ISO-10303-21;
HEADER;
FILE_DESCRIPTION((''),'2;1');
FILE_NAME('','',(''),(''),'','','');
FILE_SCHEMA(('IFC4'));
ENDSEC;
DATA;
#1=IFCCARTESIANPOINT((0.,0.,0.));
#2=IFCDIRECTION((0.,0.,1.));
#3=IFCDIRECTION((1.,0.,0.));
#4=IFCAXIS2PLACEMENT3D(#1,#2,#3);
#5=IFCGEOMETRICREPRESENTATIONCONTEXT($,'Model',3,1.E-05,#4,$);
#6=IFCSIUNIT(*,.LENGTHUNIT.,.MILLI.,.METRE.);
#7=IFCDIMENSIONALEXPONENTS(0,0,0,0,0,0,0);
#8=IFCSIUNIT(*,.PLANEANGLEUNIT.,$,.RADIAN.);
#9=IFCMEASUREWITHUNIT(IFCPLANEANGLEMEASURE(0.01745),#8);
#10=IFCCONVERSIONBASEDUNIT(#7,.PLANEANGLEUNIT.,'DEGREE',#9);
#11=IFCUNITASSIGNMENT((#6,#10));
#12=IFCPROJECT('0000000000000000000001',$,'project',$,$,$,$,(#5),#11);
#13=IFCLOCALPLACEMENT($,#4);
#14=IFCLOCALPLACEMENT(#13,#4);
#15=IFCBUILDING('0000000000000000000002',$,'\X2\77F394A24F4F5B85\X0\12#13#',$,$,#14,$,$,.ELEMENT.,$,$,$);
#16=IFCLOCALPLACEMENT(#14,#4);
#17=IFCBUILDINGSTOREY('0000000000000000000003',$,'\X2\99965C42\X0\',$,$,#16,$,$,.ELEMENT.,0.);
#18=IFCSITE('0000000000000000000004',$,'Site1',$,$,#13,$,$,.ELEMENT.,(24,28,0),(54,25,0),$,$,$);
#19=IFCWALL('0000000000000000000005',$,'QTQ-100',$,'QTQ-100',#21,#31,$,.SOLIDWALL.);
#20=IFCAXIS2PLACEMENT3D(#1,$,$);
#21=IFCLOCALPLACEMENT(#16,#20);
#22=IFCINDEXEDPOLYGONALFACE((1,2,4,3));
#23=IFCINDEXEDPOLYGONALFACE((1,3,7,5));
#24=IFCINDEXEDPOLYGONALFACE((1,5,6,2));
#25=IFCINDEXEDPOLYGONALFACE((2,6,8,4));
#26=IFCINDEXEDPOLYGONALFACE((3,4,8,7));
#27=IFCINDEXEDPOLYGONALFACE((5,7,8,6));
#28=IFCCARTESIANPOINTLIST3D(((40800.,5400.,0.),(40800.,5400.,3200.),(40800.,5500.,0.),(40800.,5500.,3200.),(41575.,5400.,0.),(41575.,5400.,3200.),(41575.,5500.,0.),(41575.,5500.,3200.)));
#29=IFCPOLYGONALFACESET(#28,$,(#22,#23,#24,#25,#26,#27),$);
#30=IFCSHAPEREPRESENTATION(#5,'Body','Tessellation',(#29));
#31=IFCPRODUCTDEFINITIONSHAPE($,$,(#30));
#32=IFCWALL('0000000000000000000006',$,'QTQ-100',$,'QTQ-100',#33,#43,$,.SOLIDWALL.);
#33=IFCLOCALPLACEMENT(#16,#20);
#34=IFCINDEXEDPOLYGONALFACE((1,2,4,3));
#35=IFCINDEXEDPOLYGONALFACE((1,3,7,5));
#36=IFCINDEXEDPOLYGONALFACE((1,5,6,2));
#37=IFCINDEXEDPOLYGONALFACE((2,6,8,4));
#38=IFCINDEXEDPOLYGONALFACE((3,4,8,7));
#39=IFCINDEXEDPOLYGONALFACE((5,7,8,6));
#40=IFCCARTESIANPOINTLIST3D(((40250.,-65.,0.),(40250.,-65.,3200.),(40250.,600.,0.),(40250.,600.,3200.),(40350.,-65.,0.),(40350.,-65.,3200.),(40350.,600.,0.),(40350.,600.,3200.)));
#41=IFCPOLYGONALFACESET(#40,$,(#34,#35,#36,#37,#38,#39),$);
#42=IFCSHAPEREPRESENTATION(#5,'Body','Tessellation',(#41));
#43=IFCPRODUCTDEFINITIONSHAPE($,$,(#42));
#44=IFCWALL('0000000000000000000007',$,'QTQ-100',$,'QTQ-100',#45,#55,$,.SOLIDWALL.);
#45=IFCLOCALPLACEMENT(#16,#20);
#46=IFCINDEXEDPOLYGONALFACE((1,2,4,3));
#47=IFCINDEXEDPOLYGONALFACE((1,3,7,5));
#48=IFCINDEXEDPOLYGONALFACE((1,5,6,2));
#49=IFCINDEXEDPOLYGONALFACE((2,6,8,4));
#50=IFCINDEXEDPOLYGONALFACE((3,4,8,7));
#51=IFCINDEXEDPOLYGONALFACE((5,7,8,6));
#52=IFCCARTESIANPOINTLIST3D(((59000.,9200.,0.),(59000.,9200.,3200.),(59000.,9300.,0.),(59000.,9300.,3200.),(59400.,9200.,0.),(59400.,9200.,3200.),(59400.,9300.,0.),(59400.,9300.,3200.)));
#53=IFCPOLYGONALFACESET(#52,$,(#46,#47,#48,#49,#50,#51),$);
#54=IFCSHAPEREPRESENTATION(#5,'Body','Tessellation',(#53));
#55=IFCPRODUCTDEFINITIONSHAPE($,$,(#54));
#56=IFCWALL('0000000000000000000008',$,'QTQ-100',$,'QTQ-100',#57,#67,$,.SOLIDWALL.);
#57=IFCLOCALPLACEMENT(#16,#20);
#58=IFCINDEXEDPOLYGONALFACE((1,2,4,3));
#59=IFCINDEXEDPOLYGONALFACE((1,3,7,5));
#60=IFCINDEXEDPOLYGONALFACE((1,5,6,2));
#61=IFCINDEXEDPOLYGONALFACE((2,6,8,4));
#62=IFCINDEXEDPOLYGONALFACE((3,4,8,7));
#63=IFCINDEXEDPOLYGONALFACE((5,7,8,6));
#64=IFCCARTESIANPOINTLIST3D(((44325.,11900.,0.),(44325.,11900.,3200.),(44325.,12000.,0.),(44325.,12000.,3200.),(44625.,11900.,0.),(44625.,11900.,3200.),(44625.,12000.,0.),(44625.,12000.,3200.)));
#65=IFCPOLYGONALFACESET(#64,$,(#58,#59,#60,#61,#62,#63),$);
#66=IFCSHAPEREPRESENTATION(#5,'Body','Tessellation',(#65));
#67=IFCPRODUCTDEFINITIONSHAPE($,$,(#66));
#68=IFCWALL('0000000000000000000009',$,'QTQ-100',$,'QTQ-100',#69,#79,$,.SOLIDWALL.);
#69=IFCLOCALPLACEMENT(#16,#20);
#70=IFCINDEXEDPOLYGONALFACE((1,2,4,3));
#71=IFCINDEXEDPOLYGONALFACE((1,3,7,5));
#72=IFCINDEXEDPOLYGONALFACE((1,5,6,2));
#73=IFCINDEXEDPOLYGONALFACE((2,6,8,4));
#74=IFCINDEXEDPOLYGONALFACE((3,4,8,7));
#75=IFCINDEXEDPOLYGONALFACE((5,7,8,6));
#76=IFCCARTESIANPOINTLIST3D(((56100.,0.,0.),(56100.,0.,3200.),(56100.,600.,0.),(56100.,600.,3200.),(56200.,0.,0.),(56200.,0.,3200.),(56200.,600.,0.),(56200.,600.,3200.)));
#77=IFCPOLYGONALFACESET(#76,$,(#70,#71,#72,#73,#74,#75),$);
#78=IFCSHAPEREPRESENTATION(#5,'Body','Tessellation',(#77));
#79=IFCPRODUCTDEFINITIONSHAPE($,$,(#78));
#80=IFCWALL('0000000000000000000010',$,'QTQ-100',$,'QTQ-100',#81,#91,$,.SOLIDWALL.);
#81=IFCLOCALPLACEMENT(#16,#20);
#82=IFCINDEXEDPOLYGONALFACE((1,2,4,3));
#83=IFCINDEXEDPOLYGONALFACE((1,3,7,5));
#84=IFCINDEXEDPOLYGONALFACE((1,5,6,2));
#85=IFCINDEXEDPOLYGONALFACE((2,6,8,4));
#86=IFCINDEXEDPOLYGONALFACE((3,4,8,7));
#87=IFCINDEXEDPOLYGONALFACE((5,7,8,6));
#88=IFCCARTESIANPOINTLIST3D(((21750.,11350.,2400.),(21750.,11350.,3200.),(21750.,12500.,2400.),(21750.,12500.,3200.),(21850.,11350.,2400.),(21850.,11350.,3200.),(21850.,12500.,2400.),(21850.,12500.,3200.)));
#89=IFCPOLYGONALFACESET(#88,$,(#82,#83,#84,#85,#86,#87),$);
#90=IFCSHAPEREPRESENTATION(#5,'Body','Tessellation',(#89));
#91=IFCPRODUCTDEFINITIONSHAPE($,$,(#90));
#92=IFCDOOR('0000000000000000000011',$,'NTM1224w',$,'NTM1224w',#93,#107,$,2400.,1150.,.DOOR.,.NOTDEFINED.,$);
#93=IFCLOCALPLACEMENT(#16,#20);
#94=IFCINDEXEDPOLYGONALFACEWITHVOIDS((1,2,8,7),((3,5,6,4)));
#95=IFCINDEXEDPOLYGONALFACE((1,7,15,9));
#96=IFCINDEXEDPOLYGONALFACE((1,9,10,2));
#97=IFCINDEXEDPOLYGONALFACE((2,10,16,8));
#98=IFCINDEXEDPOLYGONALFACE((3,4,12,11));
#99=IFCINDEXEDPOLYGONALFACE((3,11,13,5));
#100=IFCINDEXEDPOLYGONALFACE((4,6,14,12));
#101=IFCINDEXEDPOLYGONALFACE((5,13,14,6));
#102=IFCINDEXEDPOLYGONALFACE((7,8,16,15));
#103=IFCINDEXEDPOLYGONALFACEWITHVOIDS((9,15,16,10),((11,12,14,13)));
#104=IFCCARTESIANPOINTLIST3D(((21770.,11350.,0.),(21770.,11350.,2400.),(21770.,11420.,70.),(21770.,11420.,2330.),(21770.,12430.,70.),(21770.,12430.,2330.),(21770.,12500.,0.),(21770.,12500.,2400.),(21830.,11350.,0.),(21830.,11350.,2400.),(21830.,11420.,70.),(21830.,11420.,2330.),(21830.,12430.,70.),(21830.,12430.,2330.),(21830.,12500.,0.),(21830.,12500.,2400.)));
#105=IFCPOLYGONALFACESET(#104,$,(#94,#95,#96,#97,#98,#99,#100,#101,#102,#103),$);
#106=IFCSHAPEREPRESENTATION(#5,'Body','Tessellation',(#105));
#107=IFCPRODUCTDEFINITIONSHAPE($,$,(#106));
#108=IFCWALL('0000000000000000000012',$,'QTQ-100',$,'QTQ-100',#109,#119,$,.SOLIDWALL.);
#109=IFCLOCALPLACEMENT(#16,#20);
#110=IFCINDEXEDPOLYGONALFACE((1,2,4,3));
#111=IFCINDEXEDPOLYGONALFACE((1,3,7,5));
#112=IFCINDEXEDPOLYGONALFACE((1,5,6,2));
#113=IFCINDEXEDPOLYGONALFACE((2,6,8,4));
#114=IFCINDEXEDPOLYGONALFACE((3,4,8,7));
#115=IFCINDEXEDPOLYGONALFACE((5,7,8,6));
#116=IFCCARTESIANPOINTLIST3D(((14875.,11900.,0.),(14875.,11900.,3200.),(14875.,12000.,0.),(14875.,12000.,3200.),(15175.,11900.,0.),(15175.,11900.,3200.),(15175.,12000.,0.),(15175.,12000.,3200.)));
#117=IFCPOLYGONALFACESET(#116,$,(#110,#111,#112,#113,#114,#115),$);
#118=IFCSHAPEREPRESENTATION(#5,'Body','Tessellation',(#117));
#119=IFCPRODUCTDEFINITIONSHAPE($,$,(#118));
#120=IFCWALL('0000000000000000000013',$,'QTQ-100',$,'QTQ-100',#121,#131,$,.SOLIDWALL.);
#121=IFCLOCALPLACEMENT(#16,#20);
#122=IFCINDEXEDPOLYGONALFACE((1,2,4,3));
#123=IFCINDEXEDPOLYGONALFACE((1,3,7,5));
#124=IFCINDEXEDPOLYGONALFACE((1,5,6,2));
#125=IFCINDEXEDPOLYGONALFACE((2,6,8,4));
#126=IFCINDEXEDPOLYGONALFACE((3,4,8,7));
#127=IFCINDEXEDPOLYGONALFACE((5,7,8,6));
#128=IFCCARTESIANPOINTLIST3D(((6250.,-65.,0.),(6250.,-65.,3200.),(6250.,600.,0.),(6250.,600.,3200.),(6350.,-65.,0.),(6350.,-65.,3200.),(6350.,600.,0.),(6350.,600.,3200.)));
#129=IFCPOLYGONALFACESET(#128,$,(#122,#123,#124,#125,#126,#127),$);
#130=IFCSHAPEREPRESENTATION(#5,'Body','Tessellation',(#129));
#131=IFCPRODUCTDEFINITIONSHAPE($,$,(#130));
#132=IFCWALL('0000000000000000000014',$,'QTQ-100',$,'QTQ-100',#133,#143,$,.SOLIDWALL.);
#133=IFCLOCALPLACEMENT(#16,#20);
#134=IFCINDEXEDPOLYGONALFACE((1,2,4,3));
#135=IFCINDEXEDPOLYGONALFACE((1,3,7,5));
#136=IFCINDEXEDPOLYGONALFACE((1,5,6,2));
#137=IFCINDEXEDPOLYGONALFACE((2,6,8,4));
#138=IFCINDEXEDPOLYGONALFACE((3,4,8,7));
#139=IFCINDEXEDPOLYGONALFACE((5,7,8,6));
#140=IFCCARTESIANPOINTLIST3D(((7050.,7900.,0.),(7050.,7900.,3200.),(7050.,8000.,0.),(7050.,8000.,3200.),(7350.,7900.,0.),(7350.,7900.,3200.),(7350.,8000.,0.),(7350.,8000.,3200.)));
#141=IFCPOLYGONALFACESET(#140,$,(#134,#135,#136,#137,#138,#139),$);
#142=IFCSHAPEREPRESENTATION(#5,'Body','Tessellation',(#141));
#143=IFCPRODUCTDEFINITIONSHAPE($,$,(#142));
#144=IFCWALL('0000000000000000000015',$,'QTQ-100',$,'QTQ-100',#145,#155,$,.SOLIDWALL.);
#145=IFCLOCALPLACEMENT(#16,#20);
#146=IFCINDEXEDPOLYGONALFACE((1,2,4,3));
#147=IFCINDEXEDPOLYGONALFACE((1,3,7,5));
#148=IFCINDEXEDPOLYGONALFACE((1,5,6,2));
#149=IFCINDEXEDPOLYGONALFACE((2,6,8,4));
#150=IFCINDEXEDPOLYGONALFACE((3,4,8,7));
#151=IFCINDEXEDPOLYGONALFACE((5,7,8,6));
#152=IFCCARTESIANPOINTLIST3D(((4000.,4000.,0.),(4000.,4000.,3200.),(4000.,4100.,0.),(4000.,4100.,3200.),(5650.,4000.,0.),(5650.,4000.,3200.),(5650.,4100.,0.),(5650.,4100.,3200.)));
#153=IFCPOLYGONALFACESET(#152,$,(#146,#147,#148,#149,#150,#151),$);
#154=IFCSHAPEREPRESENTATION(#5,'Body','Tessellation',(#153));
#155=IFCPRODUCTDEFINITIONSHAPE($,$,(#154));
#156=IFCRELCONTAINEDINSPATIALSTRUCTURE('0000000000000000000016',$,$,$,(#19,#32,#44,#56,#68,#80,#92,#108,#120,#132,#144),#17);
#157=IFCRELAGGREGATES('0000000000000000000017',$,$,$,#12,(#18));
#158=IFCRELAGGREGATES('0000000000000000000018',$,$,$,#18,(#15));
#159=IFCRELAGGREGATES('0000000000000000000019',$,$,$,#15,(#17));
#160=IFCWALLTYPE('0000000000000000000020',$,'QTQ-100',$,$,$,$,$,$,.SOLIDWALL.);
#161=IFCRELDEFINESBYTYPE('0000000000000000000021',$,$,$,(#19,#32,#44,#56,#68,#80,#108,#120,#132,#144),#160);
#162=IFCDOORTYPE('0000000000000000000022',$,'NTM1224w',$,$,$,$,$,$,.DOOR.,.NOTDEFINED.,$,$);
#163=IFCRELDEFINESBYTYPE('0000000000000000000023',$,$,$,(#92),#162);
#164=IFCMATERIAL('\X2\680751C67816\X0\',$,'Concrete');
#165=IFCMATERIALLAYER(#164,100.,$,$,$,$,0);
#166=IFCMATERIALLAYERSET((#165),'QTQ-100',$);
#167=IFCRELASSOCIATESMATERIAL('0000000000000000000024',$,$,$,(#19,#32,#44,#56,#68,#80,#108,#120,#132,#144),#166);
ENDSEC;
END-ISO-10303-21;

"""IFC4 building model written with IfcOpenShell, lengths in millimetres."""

from ifc_helpers import new_model, entity, si_unit, converted_unit, frame, origin_with_axes, place, context, project, spatial, polyline, outline, extrude, material, layer, layer_set, type_object, element, fill, save


model = new_model("IFC4")

# Units and contexts
model_context = context("Model", 3, precision=1e-05, world=origin_with_axes())
ifc_project = project(units=[si_unit("LENGTHUNIT", "METRE", prefix="MILLI"), converted_unit("PLANEANGLEUNIT", "DEGREE", entity("IfcPlaneAngleMeasure", 0.01745), si_unit("PLANEANGLEUNIT", "RADIAN"), dimensions=[0, 0, 0, 0, 0, 0, 0])], contexts=[model_context])

# Site, building, storey
site_placement = place(None, origin_with_axes())
site = spatial("IfcSite", under=ifc_project, at=site_placement, Name="Site1", CompositionType="ELEMENT", RefLatitude=(24, 28, 0), RefLongitude=(54, 25, 0))
building_placement = place(site_placement, origin_with_axes())
building = spatial("IfcBuilding", under=site, at=building_placement, Name="石钢住宅12#13#", CompositionType="ELEMENT")
storey_placement = place(building_placement, origin_with_axes())
storey = spatial("IfcBuildingStorey", under=building, at=storey_placement, Name="首层", CompositionType="ELEMENT", Elevation=0.0)

# Walls
ifc_material = material(Name="标准砖", Category="Concrete")
ifc_layer = layer(ifc_material, 100.0, Priority=0)
ifc_layer_set = layer_set([ifc_layer], Name="QTQ-100")
wall_type = type_object("IfcWallType", Name="QTQ-100", PredefinedType="SOLIDWALL")
wall_1_placement = place(storey_placement, origin_with_axes())
element("IfcWall", 1, at=wall_1_placement, inside=storey, type_object=wall_type, material=ifc_layer_set, Name="QTQ-100", ObjectType="QTQ-100", PredefinedType="SOLIDWALL", context=model_context, shape_type="SweptSolid", body=[
    extrude(outline(polyline([(0.0, 0.0), (3200.0, 0.0), (3200.0, 775.0), (0.0, 775.0), (0.0, 0.0)])), frame((41575.0, 5400.0, 3200.0), z_axis=(0.0, 1.0, 0.0), x_axis=(0.0, 0.0, -1.0)), (0.0, 0.0, 1.0), 100.0),
])
wall_2_placement = place(storey_placement, origin_with_axes())
element("IfcWall", 2, at=wall_2_placement, inside=storey, type_object=wall_type, material=ifc_layer_set, Name="QTQ-100", ObjectType="QTQ-100", PredefinedType="SOLIDWALL", context=model_context, shape_type="SweptSolid", body=[
    extrude(outline(polyline([(0.0, 0.0), (3200.0, 0.0), (3200.0, 665.0), (0.0, 665.0), (0.0, 0.0)])), frame((40350.0, 600.0, 3200.0), z_axis=(-1.0, 0.0, 0.0), x_axis=(0.0, 0.0, -1.0)), (0.0, 0.0, 1.0), 100.0),
])
wall_3_placement = place(storey_placement, origin_with_axes())
element("IfcWall", 3, at=wall_3_placement, inside=storey, type_object=wall_type, material=ifc_layer_set, Name="QTQ-100", ObjectType="QTQ-100", PredefinedType="SOLIDWALL", context=model_context, shape_type="SweptSolid", body=[
    extrude(outline(polyline([(0.0, 0.0), (3200.0, 0.0), (3200.0, 400.0), (0.0, 400.0), (0.0, 0.0)])), frame((59400.0, 9200.0, 3200.0), z_axis=(0.0, 1.0, 0.0), x_axis=(0.0, 0.0, -1.0)), (0.0, 0.0, 1.0), 100.0),
])
wall_4_placement = place(storey_placement, origin_with_axes())
element("IfcWall", 4, at=wall_4_placement, inside=storey, type_object=wall_type, material=ifc_layer_set, Name="QTQ-100", ObjectType="QTQ-100", PredefinedType="SOLIDWALL", context=model_context, shape_type="SweptSolid", body=[
    extrude(outline(polyline([(0.0, 0.0), (3200.0, 0.0), (3200.0, 300.0), (0.0, 300.0), (0.0, 0.0)])), frame((44625.0, 11900.0, 3200.0), z_axis=(0.0, 1.0, 0.0), x_axis=(0.0, 0.0, -1.0)), (0.0, 0.0, 1.0), 100.0),
])
wall_5_placement = place(storey_placement, origin_with_axes())
element("IfcWall", 5, at=wall_5_placement, inside=storey, type_object=wall_type, material=ifc_layer_set, Name="QTQ-100", ObjectType="QTQ-100", PredefinedType="SOLIDWALL", context=model_context, shape_type="SweptSolid", body=[
    extrude(outline(polyline([(0.0, 0.0), (3200.0, 0.0), (3200.0, 600.0), (0.0, 600.0), (0.0, 0.0)])), frame((56200.0, 600.0, 3200.0), z_axis=(-1.0, 0.0, 0.0), x_axis=(0.0, 0.0, -1.0)), (0.0, 0.0, 1.0), 100.0),
])

# Wall, opening, door
wall_6_placement = place(storey_placement, origin_with_axes())
wall_6 = element("IfcWall", 6, at=wall_6_placement, inside=storey, type_object=wall_type, material=ifc_layer_set, Name="QTQ-100", ObjectType="QTQ-100", PredefinedType="SOLIDWALL", context=model_context, shape_type="SweptSolid", body=[
    extrude(outline(polyline([(0.0, 0.0), (3200.0, 0.0), (3200.0, 1150.0), (0.0, 1150.0), (0.0, 0.0)])), frame((21850.0, 12500.0, 3200.0), z_axis=(-1.0, 0.0, 0.0), x_axis=(0.0, 0.0, -1.0)), (0.0, 0.0, 1.0), 100.0),
])
opening_1_placement = place(storey_placement, origin_with_axes())
opening_1 = element("IfcOpeningElement", 7, at=opening_1_placement, cuts=wall_6, PredefinedType="OPENING", context=model_context, shape_type="SweptSolid", body=[
    extrude(outline(polyline([(0.0, 0.0), (1150.0, 0.0), (1150.0, 2400.0), (0.0, 2400.0), (0.0, 0.0)])), frame((22850.0, 12500.0, 0.0), z_axis=(-1.0, 0.0, 0.0), x_axis=(0.0, -1.0, 0.0)), (0.0, 0.0, 1.0), 2100.0),
])
door_type_1 = type_object("IfcDoorType", Name="NTM1224w", OperationType="NOTDEFINED", PredefinedType="DOOR")
door_1_placement = place(storey_placement, origin_with_axes())
door_1 = element("IfcDoor", 8, at=door_1_placement, inside=storey, type_object=door_type_1, Name="NTM1224w", ObjectType="NTM1224w", OperationType="NOTDEFINED", OverallHeight=2400.0, OverallWidth=1150.0, PredefinedType="DOOR", context=model_context, shape_type="SweptSolid", body=[
    extrude(outline(polyline([(-575.0, -1200.0), (575.0, -1200.0), (575.0, 1200.0), (-575.0, 1200.0), (-575.0, -1200.0)]), holes=[polyline([(-505.0, -1130.0), (-505.0, 1130.0), (505.0, 1130.0), (505.0, -1130.0), (-505.0, -1130.0)])]), frame((21830.0, 11925.0, 1200.0), z_axis=(-1.0, 0.0, 0.0), x_axis=(0.0, -1.0, 0.0)), (0.0, 0.0, 1.0), 60.0),
])
fill(opening_1, door_1)

# Walls
wall_7_placement = place(storey_placement, origin_with_axes())
element("IfcWall", 9, at=wall_7_placement, inside=storey, type_object=wall_type, material=ifc_layer_set, Name="QTQ-100", ObjectType="QTQ-100", PredefinedType="SOLIDWALL", context=model_context, shape_type="SweptSolid", body=[
    extrude(outline(polyline([(0.0, 0.0), (3200.0, 0.0), (3200.0, 300.0), (0.0, 300.0), (0.0, 0.0)])), frame((14875.0, 12000.0, 3200.0), z_axis=(0.0, -1.0, 0.0), x_axis=(0.0, 0.0, -1.0)), (0.0, 0.0, 1.0), 100.0),
])
wall_8_placement = place(storey_placement, origin_with_axes())
element("IfcWall", 10, at=wall_8_placement, inside=storey, type_object=wall_type, material=ifc_layer_set, Name="QTQ-100", ObjectType="QTQ-100", PredefinedType="SOLIDWALL", context=model_context, shape_type="SweptSolid", body=[
    extrude(outline(polyline([(0.0, 0.0), (3200.0, 0.0), (3200.0, 665.0), (0.0, 665.0), (0.0, 0.0)])), frame((6350.0, 600.0, 3200.0), z_axis=(-1.0, 0.0, 0.0), x_axis=(0.0, 0.0, -1.0)), (0.0, 0.0, 1.0), 100.0),
])
wall_9_placement = place(storey_placement, origin_with_axes())
element("IfcWall", 11, at=wall_9_placement, inside=storey, type_object=wall_type, material=ifc_layer_set, Name="QTQ-100", ObjectType="QTQ-100", PredefinedType="SOLIDWALL", context=model_context, shape_type="SweptSolid", body=[
    extrude(outline(polyline([(0.0, 0.0), (3200.0, 0.0), (3200.0, 300.0), (0.0, 300.0), (0.0, 0.0)])), frame((7350.0, 7900.0, 3200.0), z_axis=(0.0, 1.0, 0.0), x_axis=(0.0, 0.0, -1.0)), (0.0, 0.0, 1.0), 100.0),
])
wall_10_placement = place(storey_placement, origin_with_axes())
element("IfcWall", 12, at=wall_10_placement, inside=storey, type_object=wall_type, material=ifc_layer_set, Name="QTQ-100", ObjectType="QTQ-100", PredefinedType="SOLIDWALL", context=model_context, shape_type="SweptSolid", body=[
    extrude(outline(polyline([(0.0, 0.0), (3200.0, 0.0), (3200.0, 1650.0), (0.0, 1650.0), (0.0, 0.0)])), frame((4000.0, 4100.0, 3200.0), z_axis=(0.0, -1.0, 0.0), x_axis=(0.0, 0.0, -1.0)), (0.0, 0.0, 1.0), 100.0),
])

save(model, "model.ifc")
